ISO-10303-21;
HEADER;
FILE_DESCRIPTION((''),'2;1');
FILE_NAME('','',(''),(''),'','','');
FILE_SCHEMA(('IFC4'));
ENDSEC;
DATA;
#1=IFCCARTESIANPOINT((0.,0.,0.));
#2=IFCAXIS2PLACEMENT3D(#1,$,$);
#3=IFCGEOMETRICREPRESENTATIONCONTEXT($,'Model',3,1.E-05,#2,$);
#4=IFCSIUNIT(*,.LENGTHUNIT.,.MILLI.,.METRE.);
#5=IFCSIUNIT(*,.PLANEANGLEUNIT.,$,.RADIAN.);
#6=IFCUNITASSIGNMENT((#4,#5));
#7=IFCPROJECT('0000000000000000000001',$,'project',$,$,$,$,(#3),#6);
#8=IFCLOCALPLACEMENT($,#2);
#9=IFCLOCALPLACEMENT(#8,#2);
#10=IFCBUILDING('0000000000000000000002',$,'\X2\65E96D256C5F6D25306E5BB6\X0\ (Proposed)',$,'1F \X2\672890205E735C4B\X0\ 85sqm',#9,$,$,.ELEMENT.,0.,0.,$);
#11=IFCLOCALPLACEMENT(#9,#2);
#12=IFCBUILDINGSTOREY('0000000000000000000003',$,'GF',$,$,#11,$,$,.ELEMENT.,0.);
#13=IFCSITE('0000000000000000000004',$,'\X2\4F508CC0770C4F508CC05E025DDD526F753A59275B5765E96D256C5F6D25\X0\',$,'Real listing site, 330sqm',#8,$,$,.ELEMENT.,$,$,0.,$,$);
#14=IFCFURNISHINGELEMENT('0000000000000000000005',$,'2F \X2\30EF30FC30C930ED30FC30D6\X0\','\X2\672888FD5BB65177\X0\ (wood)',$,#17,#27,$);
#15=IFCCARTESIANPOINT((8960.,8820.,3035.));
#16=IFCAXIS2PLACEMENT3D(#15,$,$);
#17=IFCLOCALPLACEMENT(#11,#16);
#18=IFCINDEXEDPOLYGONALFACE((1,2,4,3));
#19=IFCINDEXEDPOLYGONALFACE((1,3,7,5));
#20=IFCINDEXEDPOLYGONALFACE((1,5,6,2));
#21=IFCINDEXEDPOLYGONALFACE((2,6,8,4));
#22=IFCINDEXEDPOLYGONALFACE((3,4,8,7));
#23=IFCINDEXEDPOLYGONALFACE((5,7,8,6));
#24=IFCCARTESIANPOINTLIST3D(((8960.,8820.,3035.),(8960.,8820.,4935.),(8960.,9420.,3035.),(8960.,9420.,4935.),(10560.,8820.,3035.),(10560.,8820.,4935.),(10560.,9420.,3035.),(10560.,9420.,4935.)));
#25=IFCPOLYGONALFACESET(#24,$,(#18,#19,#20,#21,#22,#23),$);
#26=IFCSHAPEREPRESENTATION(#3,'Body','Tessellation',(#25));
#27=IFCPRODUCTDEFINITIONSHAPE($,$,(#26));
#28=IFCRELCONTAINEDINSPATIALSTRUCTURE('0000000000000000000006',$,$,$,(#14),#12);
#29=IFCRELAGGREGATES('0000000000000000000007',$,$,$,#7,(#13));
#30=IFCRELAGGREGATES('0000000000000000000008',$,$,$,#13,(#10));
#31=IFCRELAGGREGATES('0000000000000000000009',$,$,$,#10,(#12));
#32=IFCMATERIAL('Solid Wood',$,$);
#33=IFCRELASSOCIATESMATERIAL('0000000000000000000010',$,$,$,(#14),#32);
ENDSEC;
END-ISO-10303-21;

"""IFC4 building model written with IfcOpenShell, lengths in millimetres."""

from ifc_helpers import new_model, si_unit, frame, frame_2d, origin, place, context, project, spatial, rectangle, extrude, material, element, save


model = new_model("IFC4")

# Units and contexts
model_context = context("Model", 3, precision=1e-05, world=origin())
ifc_project = project(units=[si_unit("LENGTHUNIT", "METRE", prefix="MILLI"), si_unit("PLANEANGLEUNIT", "RADIAN")], contexts=[model_context])

# Site, building, storey
site_placement = place(None, origin())
site = spatial("IfcSite", under=ifc_project, at=site_placement, Name="佐賀県佐賀市川副町大字早津江津", ObjectType="Real listing site, 330sqm", CompositionType="ELEMENT", RefElevation=0.0)
building_placement = place(site_placement, origin())
building = spatial("IfcBuilding", under=site, at=building_placement, Name="早津江津の家 (Proposed)", ObjectType="1F 木造平屋 85sqm", CompositionType="ELEMENT", ElevationOfRefHeight=0.0, ElevationOfTerrain=0.0)
storey_placement = place(building_placement, origin())
storey = spatial("IfcBuildingStorey", under=building, at=storey_placement, Name="GF", CompositionType="ELEMENT", Elevation=0.0)

# Shared definitions
ifc_material_1 = material(Name="Solid Wood")

# Furnishing element
furnishing_1_placement = place(storey_placement, frame((8960.0, 8820.0, 3035.0)))
element("IfcFurnishingElement", 1, at=furnishing_1_placement, inside=storey, material=ifc_material_1, Name="2F ワードローブ", Description="木製家具 (wood)", context=model_context, shape_type="SweptSolid", body=[
    extrude(rectangle(XDim=1600.0, YDim=600.0, at=frame_2d((800.0, 300.0))), frame((8960.0, 8820.0, 3035.0)), (0.0, 0.0, 1.0), 1900.0),
])

save(model, "model.ifc")
